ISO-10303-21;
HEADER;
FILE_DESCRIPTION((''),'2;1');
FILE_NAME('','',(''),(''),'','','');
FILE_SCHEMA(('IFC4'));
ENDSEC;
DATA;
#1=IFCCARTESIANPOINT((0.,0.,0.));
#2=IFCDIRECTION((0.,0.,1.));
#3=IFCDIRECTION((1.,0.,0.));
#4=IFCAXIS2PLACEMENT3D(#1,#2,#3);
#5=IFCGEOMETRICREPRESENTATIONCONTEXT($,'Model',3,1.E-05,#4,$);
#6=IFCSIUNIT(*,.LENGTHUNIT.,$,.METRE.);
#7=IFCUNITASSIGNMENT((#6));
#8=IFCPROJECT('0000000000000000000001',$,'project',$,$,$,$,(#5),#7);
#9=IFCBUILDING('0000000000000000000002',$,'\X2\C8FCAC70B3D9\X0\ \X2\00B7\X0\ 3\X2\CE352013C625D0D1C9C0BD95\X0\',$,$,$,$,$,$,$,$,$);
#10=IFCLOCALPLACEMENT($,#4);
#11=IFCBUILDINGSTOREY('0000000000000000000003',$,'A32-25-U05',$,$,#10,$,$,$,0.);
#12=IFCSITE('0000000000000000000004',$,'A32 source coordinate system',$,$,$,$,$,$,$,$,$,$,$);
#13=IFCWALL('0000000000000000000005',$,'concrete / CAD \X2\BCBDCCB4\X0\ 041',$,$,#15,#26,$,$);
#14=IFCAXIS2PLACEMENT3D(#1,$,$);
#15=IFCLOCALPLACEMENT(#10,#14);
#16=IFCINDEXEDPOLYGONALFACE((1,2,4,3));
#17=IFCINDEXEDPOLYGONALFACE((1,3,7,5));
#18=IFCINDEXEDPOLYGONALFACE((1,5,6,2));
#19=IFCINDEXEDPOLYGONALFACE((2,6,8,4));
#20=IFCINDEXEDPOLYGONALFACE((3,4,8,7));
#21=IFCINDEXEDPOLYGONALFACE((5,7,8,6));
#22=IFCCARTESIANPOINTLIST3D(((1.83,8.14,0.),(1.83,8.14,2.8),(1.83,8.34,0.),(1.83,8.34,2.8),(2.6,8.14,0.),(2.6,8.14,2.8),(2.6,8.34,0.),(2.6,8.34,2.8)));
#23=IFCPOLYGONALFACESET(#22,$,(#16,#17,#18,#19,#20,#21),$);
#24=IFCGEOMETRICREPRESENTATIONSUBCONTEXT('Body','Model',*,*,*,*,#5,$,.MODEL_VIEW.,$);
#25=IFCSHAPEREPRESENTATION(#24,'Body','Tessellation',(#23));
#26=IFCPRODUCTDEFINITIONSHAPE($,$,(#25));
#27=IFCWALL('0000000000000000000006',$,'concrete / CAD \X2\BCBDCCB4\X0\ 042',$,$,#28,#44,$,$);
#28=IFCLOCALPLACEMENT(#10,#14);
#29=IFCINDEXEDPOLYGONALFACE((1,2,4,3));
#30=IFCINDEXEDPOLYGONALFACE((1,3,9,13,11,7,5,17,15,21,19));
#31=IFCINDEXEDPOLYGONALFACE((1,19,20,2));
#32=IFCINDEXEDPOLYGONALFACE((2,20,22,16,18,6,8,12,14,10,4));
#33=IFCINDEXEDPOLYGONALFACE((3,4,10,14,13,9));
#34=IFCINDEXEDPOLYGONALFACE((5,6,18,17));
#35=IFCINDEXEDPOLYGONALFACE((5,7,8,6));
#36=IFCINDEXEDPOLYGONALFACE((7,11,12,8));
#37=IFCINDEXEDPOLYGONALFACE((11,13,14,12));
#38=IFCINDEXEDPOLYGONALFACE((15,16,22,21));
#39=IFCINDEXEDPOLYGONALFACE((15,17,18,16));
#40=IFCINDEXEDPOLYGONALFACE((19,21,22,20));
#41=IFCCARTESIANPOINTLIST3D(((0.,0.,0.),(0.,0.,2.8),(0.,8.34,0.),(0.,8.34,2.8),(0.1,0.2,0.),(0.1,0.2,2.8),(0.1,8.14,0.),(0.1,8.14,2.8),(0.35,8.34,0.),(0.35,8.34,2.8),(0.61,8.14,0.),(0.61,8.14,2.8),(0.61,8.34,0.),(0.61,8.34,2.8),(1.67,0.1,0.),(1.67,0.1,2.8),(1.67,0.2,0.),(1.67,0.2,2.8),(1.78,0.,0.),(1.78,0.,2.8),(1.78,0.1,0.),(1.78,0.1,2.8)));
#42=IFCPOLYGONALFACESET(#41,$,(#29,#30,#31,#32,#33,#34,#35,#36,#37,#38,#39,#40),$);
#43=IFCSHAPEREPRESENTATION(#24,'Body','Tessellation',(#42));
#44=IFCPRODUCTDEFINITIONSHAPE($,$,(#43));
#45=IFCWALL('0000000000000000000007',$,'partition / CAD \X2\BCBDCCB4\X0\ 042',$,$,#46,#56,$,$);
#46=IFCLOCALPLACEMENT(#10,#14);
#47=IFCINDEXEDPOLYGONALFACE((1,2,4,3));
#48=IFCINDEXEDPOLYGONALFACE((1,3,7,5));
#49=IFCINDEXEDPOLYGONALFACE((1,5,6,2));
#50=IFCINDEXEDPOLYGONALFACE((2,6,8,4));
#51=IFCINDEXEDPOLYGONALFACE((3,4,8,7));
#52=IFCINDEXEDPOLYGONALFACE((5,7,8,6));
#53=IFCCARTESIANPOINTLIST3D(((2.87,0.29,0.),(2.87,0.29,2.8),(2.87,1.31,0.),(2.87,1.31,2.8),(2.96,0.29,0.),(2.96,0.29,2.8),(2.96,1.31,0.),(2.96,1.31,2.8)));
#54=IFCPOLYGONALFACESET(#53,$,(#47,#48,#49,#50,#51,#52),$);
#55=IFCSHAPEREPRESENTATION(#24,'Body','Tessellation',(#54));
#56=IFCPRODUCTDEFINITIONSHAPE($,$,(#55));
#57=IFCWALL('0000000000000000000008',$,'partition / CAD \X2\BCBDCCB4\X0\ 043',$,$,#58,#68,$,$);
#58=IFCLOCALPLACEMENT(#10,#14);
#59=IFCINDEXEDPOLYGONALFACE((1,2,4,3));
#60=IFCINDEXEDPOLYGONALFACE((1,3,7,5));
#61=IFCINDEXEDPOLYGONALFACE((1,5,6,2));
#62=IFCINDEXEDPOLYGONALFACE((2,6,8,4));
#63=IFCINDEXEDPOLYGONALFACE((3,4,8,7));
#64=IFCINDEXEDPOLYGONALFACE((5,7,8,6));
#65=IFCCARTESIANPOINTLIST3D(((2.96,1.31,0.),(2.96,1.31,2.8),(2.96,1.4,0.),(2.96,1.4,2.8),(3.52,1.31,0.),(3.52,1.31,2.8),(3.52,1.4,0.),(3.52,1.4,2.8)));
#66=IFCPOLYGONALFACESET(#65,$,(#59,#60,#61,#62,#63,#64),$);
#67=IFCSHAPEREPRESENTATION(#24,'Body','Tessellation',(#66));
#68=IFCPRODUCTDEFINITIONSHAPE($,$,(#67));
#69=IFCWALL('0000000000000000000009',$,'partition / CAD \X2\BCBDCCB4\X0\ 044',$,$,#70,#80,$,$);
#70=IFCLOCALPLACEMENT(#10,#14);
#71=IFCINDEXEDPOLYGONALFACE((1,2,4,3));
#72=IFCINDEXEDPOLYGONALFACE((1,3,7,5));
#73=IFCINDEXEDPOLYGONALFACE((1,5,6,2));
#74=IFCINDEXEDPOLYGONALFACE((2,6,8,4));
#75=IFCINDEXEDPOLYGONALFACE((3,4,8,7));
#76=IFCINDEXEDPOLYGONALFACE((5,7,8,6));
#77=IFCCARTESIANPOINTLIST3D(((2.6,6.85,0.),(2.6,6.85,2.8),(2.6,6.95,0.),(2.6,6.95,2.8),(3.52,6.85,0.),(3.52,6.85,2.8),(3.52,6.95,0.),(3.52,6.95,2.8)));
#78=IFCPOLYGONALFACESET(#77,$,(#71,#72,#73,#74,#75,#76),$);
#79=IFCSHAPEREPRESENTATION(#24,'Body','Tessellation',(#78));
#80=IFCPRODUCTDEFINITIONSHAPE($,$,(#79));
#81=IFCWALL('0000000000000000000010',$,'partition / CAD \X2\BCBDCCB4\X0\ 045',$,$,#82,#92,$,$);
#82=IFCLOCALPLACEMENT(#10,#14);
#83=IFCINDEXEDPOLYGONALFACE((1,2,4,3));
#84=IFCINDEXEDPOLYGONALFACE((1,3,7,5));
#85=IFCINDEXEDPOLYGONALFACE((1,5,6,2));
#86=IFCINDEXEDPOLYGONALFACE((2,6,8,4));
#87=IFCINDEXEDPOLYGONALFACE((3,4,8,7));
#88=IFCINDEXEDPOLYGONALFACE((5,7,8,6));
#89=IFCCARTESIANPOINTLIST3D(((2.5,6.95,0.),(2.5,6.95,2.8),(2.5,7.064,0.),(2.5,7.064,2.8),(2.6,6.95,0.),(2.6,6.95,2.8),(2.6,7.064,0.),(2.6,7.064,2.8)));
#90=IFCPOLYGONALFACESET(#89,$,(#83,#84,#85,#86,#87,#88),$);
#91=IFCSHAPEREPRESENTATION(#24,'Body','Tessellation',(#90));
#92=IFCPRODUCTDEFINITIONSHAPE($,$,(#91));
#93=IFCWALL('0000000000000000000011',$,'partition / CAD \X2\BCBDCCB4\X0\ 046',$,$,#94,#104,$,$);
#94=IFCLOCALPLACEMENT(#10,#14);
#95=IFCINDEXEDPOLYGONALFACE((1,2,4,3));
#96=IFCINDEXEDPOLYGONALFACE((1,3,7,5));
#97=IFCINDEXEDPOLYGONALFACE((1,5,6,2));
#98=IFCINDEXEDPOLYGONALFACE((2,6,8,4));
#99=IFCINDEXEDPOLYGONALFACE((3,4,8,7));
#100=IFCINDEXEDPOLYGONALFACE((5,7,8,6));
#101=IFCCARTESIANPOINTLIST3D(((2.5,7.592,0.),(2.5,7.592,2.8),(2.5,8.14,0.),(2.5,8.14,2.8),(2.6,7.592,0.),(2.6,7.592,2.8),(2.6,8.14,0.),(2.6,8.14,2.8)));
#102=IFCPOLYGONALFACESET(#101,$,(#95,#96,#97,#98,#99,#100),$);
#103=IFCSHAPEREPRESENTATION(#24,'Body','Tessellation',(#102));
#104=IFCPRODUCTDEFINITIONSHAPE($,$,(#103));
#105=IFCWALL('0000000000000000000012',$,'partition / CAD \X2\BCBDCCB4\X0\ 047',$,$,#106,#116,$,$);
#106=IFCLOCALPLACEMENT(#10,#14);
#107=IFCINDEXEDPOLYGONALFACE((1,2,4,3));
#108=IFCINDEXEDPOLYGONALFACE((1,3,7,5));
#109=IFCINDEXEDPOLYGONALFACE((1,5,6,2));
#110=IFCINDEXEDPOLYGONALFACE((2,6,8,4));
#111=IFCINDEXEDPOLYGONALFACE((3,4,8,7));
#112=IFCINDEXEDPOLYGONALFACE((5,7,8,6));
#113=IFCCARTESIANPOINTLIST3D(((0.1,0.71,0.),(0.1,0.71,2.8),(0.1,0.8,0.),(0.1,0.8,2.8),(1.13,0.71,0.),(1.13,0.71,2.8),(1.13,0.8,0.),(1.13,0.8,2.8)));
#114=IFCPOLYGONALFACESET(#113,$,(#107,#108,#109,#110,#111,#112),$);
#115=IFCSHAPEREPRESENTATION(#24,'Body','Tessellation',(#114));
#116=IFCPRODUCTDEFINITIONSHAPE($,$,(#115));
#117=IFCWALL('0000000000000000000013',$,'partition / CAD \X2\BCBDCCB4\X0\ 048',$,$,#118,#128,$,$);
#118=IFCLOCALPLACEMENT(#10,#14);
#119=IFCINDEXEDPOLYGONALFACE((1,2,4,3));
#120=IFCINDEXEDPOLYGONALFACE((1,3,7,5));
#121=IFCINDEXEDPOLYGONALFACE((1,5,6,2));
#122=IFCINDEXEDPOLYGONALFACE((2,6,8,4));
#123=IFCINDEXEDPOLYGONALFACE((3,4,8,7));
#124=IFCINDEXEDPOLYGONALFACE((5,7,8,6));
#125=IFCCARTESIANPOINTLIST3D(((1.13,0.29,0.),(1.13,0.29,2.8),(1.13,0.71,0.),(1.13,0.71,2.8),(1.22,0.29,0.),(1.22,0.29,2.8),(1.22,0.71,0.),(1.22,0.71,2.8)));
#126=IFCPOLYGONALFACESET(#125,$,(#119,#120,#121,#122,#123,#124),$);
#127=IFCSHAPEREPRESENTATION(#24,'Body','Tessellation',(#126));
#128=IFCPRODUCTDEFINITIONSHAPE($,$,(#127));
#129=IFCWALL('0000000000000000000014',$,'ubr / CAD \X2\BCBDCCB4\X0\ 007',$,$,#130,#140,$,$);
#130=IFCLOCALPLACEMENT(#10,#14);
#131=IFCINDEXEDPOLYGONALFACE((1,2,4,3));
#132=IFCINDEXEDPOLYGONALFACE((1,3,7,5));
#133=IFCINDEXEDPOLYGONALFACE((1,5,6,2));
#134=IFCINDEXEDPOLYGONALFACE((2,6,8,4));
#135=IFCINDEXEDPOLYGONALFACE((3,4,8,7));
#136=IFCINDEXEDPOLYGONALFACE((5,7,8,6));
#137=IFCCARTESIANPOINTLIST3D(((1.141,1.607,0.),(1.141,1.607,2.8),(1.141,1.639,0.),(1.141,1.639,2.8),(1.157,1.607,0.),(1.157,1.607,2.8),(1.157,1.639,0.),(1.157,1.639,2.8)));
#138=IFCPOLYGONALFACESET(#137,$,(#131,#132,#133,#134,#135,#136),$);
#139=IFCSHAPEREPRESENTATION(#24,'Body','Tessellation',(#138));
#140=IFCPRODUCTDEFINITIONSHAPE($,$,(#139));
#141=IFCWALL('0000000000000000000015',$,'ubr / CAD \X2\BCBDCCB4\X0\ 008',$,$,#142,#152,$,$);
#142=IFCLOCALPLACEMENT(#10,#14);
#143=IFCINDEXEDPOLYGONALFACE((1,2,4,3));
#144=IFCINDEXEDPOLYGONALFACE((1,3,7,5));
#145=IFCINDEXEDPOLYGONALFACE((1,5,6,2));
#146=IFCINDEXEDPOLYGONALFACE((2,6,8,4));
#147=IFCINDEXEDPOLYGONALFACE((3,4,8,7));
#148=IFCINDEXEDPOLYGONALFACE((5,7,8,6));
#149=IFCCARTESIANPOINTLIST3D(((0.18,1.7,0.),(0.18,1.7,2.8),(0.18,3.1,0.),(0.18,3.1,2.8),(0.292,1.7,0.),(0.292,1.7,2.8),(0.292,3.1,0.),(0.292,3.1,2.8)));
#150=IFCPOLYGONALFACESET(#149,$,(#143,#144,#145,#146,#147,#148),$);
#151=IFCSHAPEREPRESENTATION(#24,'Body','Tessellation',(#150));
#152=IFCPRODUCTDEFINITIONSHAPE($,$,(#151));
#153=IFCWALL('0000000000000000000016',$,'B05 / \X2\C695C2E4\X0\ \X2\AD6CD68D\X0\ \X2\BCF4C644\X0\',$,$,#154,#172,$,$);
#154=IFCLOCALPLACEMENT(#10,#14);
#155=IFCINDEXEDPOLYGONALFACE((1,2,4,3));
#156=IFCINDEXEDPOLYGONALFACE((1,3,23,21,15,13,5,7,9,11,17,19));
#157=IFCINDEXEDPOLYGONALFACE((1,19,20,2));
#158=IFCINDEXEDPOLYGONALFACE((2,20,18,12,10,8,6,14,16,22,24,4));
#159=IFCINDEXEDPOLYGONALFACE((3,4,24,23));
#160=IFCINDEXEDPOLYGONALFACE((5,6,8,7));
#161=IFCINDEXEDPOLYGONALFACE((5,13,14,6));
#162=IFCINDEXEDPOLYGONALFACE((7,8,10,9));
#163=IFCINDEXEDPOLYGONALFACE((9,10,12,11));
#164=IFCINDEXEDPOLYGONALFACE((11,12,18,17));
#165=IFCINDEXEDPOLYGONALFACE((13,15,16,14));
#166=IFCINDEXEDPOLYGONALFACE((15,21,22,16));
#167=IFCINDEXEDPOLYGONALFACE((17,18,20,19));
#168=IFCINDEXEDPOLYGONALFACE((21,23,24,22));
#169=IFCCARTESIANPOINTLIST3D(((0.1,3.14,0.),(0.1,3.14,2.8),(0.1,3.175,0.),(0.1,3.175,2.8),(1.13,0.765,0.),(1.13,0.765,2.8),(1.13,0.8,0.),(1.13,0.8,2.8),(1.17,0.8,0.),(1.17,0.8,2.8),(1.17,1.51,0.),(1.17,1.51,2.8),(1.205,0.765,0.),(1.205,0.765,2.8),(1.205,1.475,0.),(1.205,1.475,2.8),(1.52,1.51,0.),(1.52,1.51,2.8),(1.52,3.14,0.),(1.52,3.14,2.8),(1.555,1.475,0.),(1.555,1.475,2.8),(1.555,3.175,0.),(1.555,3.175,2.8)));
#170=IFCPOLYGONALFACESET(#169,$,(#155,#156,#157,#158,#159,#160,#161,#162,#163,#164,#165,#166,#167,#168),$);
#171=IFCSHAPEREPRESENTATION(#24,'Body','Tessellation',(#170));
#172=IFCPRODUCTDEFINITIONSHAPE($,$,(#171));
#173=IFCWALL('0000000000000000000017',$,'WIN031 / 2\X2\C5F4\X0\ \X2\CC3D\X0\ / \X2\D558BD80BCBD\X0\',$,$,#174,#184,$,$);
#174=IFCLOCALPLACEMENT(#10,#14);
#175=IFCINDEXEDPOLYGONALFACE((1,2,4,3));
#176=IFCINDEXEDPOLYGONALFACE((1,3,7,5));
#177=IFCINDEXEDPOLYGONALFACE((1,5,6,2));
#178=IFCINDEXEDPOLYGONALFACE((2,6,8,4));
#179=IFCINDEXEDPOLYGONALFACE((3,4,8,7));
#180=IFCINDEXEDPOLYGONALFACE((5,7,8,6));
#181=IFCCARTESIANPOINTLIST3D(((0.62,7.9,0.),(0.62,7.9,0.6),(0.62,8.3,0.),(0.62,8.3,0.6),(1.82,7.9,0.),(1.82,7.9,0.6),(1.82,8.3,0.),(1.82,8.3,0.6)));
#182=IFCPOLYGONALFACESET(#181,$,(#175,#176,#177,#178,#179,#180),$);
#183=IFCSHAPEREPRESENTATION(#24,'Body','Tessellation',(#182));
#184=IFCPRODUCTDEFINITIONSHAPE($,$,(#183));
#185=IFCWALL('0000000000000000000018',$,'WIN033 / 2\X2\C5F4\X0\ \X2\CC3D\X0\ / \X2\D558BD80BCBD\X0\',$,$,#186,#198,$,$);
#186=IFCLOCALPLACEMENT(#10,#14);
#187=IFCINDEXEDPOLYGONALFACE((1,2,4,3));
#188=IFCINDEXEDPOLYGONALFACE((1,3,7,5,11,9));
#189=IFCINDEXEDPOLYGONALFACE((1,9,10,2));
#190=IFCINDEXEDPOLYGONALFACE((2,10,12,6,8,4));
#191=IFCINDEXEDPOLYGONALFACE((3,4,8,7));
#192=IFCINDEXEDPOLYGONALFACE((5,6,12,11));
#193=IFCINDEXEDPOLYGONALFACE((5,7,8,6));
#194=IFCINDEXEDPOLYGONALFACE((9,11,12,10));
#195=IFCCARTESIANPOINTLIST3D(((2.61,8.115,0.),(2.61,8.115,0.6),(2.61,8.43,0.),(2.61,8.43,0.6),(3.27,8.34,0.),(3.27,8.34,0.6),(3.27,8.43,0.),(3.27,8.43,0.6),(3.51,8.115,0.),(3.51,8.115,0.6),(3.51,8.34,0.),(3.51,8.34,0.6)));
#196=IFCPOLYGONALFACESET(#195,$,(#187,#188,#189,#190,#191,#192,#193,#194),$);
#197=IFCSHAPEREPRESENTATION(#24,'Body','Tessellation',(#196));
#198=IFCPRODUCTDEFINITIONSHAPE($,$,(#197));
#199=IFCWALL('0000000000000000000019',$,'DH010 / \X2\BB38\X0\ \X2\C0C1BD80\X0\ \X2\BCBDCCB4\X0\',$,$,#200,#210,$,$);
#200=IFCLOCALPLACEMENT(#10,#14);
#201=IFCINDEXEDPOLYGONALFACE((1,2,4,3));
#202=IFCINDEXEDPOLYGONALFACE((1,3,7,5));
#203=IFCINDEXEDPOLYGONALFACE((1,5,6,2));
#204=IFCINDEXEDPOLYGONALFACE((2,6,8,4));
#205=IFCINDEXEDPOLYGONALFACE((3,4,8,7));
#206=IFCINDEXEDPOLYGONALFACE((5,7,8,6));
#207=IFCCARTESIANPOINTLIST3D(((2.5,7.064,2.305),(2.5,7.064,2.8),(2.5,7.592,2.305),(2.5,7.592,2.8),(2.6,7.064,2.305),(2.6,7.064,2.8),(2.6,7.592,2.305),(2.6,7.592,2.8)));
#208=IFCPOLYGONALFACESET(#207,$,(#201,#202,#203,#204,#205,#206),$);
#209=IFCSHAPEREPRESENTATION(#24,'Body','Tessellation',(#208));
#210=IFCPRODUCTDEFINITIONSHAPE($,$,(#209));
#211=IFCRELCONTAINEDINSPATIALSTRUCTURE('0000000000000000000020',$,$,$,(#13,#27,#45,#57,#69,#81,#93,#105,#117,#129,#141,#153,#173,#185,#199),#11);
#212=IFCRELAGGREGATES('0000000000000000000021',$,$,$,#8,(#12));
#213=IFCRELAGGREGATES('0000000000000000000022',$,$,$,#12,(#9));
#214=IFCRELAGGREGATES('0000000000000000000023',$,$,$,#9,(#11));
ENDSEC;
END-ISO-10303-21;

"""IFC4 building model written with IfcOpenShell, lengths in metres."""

from ifc_helpers import new_model, si_unit, frame, origin, origin_with_axes, place, context, subcontext, project, spatial, polyline, outline, extrude, element, save


model = new_model("IFC4")

# Units and contexts
model_context = context("Model", 3, precision=1e-05, world=origin_with_axes())
body_context = subcontext(model_context, "Body", "Model", "MODEL_VIEW")
ifc_project = project(units=[si_unit("LENGTHUNIT", "METRE")], contexts=[model_context])

# Site, building, storey
site = spatial("IfcSite", under=ifc_project, Name="A32 source coordinate system")
building = spatial("IfcBuilding", under=site, Name="주거동 · 3층–옥탑지붕")
storey_placement = place(None, origin_with_axes())
storey = spatial("IfcBuildingStorey", under=building, at=storey_placement, Name="A32-25-U05", Elevation=0.0)

# Walls
wall_1_placement = place(storey_placement, origin_with_axes())
element("IfcWall", 1, at=wall_1_placement, inside=storey, Name="concrete / CAD 벽체 041", context=body_context, shape_type="SweptSolid", body=[
    extrude(outline(polyline([(2.6, 8.14), (1.83, 8.14), (1.83, 8.34), (2.6, 8.34), (2.6, 8.14)])), origin(), (0.0, 0.0, 1.0), 2.8),
])
wall_2_placement = place(storey_placement, origin_with_axes())
element("IfcWall", 2, at=wall_2_placement, inside=storey, Name="concrete / CAD 벽체 042", context=body_context, shape_type="SweptSolid", body=[
    extrude(outline(polyline([(0.1, 8.14), (0.1, 0.2), (1.67, 0.2), (1.67, 0.1), (1.78, 0.1), (1.78, 0.0), (0.0, 0.0), (0.0, 8.34), (0.35, 8.34), (0.35, 8.34), (0.61, 8.34), (0.61, 8.14), (0.1, 8.14)])), origin(), (0.0, 0.0, 1.0), 2.8),
])
wall_3_placement = place(storey_placement, origin_with_axes())
element("IfcWall", 3, at=wall_3_placement, inside=storey, Name="partition / CAD 벽체 042", context=body_context, shape_type="SweptSolid", body=[
    extrude(outline(polyline([(2.87, 1.31), (2.96, 1.31), (2.96, 0.29), (2.87, 0.29), (2.87, 1.31)])), origin(), (0.0, 0.0, 1.0), 2.8),
])
wall_4_placement = place(storey_placement, origin_with_axes())
element("IfcWall", 4, at=wall_4_placement, inside=storey, Name="partition / CAD 벽체 043", context=body_context, shape_type="SweptSolid", body=[
    extrude(outline(polyline([(3.52, 1.4), (3.52, 1.31), (2.96, 1.31), (2.96, 1.4), (3.52, 1.4)])), origin(), (0.0, 0.0, 1.0), 2.8),
])
wall_5_placement = place(storey_placement, origin_with_axes())
element("IfcWall", 5, at=wall_5_placement, inside=storey, Name="partition / CAD 벽체 044", context=body_context, shape_type="SweptSolid", body=[
    extrude(outline(polyline([(3.52, 6.95), (3.52, 6.85), (2.6, 6.85), (2.6, 6.95), (3.52, 6.95)])), origin(), (0.0, 0.0, 1.0), 2.8),
])
wall_6_placement = place(storey_placement, origin_with_axes())
element("IfcWall", 6, at=wall_6_placement, inside=storey, Name="partition / CAD 벽체 045", context=body_context, shape_type="SweptSolid", body=[
    extrude(outline(polyline([(2.5, 7.064), (2.6, 7.064), (2.6, 6.95), (2.5, 6.95), (2.5, 7.064)])), origin(), (0.0, 0.0, 1.0), 2.8),
])
wall_7_placement = place(storey_placement, origin_with_axes())
element("IfcWall", 7, at=wall_7_placement, inside=storey, Name="partition / CAD 벽체 046", context=body_context, shape_type="SweptSolid", body=[
    extrude(outline(polyline([(2.6, 7.592), (2.5, 7.592), (2.5, 8.14), (2.6, 8.14), (2.6, 7.592)])), origin(), (0.0, 0.0, 1.0), 2.8),
])
wall_8_placement = place(storey_placement, origin_with_axes())
element("IfcWall", 8, at=wall_8_placement, inside=storey, Name="partition / CAD 벽체 047", context=body_context, shape_type="SweptSolid", body=[
    extrude(outline(polyline([(1.13, 0.71), (0.1, 0.71), (0.1, 0.8), (1.13, 0.8), (1.13, 0.71)])), origin(), (0.0, 0.0, 1.0), 2.8),
])
wall_9_placement = place(storey_placement, origin_with_axes())
element("IfcWall", 9, at=wall_9_placement, inside=storey, Name="partition / CAD 벽체 048", context=body_context, shape_type="SweptSolid", body=[
    extrude(outline(polyline([(1.22, 0.29), (1.13, 0.29), (1.13, 0.71), (1.22, 0.71), (1.22, 0.29)])), origin(), (0.0, 0.0, 1.0), 2.8),
])
wall_10_placement = place(storey_placement, origin_with_axes())
element("IfcWall", 10, at=wall_10_placement, inside=storey, Name="ubr / CAD 벽체 007", context=body_context, shape_type="SweptSolid", body=[
    extrude(outline(polyline([(1.157, 1.607), (1.141, 1.607), (1.141, 1.639), (1.157, 1.639), (1.157, 1.607)])), origin(), (0.0, 0.0, 1.0), 2.8),
])
wall_11_placement = place(storey_placement, origin_with_axes())
element("IfcWall", 11, at=wall_11_placement, inside=storey, Name="ubr / CAD 벽체 008", context=body_context, shape_type="SweptSolid", body=[
    extrude(outline(polyline([(0.292, 1.7), (0.18, 1.7), (0.18, 3.1), (0.292, 3.1), (0.292, 1.7)])), origin(), (0.0, 0.0, 1.0), 2.8),
])
wall_12_placement = place(storey_placement, origin_with_axes())
element("IfcWall", 12, at=wall_12_placement, inside=storey, Name="B05 / 욕실 구획 보완", context=body_context, shape_type="SweptSolid", body=[
    extrude(outline(polyline([(1.17, 1.51), (1.52, 1.51), (1.52, 3.14), (0.1, 3.14), (0.1, 3.175), (1.555, 3.175), (1.555, 1.475), (1.205, 1.475), (1.205, 0.765), (1.13, 0.765), (1.13, 0.8), (1.17, 0.8), (1.17, 1.51)])), origin(), (0.0, 0.0, 1.0), 2.8),
])
wall_13_placement = place(storey_placement, origin_with_axes())
element("IfcWall", 13, at=wall_13_placement, inside=storey, Name="WIN031 / 2열 창 / 하부벽", context=body_context, shape_type="SweptSolid", body=[
    extrude(outline(polyline([(0.62, 8.3), (1.82, 8.3), (1.82, 7.9), (0.62, 7.9), (0.62, 8.3)])), origin(), (0.0, 0.0, 1.0), 0.6),
])
wall_14_placement = place(storey_placement, origin_with_axes())
element("IfcWall", 14, at=wall_14_placement, inside=storey, Name="WIN033 / 2열 창 / 하부벽", context=body_context, shape_type="SweptSolid", body=[
    extrude(outline(polyline([(2.61, 8.43), (3.27, 8.43), (3.27, 8.34), (3.51, 8.34), (3.51, 8.115), (2.61, 8.115), (2.61, 8.43)])), origin(), (0.0, 0.0, 1.0), 0.6),
])
wall_15_placement = place(storey_placement, origin_with_axes())
element("IfcWall", 15, at=wall_15_placement, inside=storey, Name="DH010 / 문 상부 벽체", context=body_context, shape_type="SweptSolid", body=[
    extrude(outline(polyline([(2.5, 7.592), (2.6, 7.592), (2.6, 7.064), (2.5, 7.064), (2.5, 7.592)])), frame((0.0, 0.0, 2.305)), (0.0, 0.0, 1.0), 0.495),
])

save(model, "model.ifc")
